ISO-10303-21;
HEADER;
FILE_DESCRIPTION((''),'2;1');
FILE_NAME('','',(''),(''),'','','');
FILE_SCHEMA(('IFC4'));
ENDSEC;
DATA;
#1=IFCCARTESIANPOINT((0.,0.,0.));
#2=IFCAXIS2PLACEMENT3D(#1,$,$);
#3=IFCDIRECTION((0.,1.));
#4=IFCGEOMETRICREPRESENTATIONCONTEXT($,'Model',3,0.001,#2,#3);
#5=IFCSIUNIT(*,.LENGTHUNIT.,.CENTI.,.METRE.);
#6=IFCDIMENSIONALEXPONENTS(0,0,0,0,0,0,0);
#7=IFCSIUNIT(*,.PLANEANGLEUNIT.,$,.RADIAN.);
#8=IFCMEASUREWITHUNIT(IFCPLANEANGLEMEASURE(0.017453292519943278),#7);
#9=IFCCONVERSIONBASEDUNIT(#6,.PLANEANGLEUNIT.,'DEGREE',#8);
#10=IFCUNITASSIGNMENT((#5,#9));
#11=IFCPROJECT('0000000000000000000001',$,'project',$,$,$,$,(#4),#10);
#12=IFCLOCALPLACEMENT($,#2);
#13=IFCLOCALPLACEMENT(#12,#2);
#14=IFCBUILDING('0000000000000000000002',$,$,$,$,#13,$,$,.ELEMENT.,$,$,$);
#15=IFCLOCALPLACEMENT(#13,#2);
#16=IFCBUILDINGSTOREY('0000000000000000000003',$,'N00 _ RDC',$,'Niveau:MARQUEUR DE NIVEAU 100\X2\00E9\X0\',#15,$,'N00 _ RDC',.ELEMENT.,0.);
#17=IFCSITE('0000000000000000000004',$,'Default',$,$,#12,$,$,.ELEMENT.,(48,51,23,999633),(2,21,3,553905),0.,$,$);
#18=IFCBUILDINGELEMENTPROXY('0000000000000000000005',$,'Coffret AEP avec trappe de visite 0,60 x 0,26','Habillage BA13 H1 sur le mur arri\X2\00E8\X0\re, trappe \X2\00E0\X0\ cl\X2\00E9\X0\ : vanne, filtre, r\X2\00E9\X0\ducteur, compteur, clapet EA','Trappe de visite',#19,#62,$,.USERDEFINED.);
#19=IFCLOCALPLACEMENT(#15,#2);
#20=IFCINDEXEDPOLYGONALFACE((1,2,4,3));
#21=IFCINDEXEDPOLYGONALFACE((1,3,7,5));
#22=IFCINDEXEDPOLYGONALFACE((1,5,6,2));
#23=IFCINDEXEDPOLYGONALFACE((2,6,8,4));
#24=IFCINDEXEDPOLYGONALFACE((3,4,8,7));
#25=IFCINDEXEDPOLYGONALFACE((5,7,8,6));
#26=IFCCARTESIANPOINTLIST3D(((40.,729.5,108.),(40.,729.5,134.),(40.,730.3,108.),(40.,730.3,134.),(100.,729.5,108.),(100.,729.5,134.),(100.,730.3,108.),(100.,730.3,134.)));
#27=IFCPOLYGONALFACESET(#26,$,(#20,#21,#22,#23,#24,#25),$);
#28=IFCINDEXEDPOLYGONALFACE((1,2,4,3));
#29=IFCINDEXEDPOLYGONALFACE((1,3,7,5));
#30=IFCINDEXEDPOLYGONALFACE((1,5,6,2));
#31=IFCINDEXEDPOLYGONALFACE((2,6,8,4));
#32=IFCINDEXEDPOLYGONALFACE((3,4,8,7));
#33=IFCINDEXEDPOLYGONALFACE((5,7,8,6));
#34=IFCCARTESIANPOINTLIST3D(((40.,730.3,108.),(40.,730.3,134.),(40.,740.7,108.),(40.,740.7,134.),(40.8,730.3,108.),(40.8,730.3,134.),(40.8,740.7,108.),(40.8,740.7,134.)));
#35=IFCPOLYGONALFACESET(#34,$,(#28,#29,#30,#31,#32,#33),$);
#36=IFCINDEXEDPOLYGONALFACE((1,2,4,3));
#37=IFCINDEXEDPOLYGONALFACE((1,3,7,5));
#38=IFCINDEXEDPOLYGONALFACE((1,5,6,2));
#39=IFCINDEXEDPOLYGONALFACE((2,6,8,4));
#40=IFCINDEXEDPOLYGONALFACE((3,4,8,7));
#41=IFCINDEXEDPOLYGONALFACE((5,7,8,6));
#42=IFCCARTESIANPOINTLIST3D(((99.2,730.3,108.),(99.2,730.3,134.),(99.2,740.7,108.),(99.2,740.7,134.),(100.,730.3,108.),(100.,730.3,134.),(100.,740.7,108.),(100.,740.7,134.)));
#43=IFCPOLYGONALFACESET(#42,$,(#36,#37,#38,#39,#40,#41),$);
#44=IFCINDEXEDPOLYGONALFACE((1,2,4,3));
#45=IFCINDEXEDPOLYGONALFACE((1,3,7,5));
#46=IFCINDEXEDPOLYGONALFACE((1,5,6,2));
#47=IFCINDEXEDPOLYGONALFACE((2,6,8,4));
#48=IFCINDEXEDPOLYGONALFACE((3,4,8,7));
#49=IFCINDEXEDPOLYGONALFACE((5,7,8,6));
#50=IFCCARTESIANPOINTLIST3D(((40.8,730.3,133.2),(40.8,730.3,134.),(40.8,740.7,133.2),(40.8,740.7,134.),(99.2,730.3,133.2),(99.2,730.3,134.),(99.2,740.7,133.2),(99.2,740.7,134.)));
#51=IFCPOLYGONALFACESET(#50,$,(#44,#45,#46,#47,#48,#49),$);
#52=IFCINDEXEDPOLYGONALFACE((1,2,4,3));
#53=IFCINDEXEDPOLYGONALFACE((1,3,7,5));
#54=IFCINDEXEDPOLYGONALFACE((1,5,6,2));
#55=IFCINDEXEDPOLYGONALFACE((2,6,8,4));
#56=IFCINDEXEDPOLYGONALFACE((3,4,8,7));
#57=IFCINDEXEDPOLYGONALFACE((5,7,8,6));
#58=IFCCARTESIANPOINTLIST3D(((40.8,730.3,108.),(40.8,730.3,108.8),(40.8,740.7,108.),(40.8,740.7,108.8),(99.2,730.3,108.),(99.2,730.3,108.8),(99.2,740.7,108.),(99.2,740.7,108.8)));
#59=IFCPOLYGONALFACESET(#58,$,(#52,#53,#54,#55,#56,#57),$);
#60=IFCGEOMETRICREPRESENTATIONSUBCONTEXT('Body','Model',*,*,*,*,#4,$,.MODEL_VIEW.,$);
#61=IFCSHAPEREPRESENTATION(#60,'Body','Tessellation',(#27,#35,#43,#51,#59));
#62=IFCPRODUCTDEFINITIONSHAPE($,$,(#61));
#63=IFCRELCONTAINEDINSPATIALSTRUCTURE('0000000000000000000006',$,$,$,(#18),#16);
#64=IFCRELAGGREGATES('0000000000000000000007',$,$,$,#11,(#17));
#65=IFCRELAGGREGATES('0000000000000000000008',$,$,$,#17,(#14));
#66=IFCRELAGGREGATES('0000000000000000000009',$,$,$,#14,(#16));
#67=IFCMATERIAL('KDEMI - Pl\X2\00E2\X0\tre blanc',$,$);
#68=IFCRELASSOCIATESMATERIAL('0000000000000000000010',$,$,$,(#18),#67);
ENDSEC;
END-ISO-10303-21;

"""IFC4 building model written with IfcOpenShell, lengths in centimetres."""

from ifc_helpers import new_model, entity, si_unit, converted_unit, direction, frame, frame_2d, origin, origin_with_axes, place, context, subcontext, project, spatial, rectangle, extrude, material, element, save


model = new_model("IFC4")

# Units and contexts
model_context = context("Model", 3, precision=0.001, world=origin(), true_north=direction((0.0, 1.0)))
body_context = subcontext(model_context, "Body", "Model", "MODEL_VIEW")
ifc_project = project(units=[si_unit("LENGTHUNIT", "METRE", prefix="CENTI"), converted_unit("PLANEANGLEUNIT", "DEGREE", entity("IfcPlaneAngleMeasure", 0.017453292519943278), si_unit("PLANEANGLEUNIT", "RADIAN"), dimensions=[0, 0, 0, 0, 0, 0, 0])], contexts=[model_context])

# Site, building, storey
site_placement = place(None, origin())
site = spatial("IfcSite", under=ifc_project, at=site_placement, Name="Default", CompositionType="ELEMENT", RefLatitude=(48, 51, 23, 999633), RefLongitude=(2, 21, 3, 553905), RefElevation=0.0)
building_placement = place(site_placement, origin())
building = spatial("IfcBuilding", under=site, at=building_placement, CompositionType="ELEMENT")
storey_placement = place(building_placement, origin())
storey = spatial("IfcBuildingStorey", under=building, at=storey_placement, Name="N00 _ RDC", ObjectType="Niveau:MARQUEUR DE NIVEAU 100é", LongName="N00 _ RDC", CompositionType="ELEMENT", Elevation=0.0)

# Building element proxy
ifc_material_1 = material(Name="KDEMI - Plâtre blanc")
proxy_1_placement = place(storey_placement, origin_with_axes())
element("IfcBuildingElementProxy", 1, at=proxy_1_placement, inside=storey, material=ifc_material_1, Name="Coffret AEP avec trappe de visite 0,60 x 0,26", Description="Habillage BA13 H1 sur le mur arrière, trappe à clé : vanne, filtre, réducteur, compteur, clapet EA", ObjectType="Trappe de visite", PredefinedType="USERDEFINED", context=body_context, shape_type="SweptSolid", body=[
    extrude(rectangle(XDim=60.0, YDim=0.8, at=frame_2d((70.0, 729.9))), frame((0.0, 0.0, 108.0)), (0.0, 0.0, 1.0), 26.0),
    extrude(rectangle(XDim=0.8, YDim=10.4, at=frame_2d((40.4, 735.5))), frame((0.0, 0.0, 108.0)), (0.0, 0.0, 1.0), 26.0),
    extrude(rectangle(XDim=0.8, YDim=10.4, at=frame_2d((99.6, 735.5))), frame((0.0, 0.0, 108.0)), (0.0, 0.0, 1.0), 26.0),
    extrude(rectangle(XDim=58.4, YDim=10.4, at=frame_2d((70.0, 735.5))), frame((0.0, 0.0, 133.2)), (0.0, 0.0, 1.0), 0.8),
    extrude(rectangle(XDim=58.4, YDim=10.4, at=frame_2d((70.0, 735.5))), frame((0.0, 0.0, 108.0)), (0.0, 0.0, 1.0), 0.8),
])

save(model, "model.ifc")
